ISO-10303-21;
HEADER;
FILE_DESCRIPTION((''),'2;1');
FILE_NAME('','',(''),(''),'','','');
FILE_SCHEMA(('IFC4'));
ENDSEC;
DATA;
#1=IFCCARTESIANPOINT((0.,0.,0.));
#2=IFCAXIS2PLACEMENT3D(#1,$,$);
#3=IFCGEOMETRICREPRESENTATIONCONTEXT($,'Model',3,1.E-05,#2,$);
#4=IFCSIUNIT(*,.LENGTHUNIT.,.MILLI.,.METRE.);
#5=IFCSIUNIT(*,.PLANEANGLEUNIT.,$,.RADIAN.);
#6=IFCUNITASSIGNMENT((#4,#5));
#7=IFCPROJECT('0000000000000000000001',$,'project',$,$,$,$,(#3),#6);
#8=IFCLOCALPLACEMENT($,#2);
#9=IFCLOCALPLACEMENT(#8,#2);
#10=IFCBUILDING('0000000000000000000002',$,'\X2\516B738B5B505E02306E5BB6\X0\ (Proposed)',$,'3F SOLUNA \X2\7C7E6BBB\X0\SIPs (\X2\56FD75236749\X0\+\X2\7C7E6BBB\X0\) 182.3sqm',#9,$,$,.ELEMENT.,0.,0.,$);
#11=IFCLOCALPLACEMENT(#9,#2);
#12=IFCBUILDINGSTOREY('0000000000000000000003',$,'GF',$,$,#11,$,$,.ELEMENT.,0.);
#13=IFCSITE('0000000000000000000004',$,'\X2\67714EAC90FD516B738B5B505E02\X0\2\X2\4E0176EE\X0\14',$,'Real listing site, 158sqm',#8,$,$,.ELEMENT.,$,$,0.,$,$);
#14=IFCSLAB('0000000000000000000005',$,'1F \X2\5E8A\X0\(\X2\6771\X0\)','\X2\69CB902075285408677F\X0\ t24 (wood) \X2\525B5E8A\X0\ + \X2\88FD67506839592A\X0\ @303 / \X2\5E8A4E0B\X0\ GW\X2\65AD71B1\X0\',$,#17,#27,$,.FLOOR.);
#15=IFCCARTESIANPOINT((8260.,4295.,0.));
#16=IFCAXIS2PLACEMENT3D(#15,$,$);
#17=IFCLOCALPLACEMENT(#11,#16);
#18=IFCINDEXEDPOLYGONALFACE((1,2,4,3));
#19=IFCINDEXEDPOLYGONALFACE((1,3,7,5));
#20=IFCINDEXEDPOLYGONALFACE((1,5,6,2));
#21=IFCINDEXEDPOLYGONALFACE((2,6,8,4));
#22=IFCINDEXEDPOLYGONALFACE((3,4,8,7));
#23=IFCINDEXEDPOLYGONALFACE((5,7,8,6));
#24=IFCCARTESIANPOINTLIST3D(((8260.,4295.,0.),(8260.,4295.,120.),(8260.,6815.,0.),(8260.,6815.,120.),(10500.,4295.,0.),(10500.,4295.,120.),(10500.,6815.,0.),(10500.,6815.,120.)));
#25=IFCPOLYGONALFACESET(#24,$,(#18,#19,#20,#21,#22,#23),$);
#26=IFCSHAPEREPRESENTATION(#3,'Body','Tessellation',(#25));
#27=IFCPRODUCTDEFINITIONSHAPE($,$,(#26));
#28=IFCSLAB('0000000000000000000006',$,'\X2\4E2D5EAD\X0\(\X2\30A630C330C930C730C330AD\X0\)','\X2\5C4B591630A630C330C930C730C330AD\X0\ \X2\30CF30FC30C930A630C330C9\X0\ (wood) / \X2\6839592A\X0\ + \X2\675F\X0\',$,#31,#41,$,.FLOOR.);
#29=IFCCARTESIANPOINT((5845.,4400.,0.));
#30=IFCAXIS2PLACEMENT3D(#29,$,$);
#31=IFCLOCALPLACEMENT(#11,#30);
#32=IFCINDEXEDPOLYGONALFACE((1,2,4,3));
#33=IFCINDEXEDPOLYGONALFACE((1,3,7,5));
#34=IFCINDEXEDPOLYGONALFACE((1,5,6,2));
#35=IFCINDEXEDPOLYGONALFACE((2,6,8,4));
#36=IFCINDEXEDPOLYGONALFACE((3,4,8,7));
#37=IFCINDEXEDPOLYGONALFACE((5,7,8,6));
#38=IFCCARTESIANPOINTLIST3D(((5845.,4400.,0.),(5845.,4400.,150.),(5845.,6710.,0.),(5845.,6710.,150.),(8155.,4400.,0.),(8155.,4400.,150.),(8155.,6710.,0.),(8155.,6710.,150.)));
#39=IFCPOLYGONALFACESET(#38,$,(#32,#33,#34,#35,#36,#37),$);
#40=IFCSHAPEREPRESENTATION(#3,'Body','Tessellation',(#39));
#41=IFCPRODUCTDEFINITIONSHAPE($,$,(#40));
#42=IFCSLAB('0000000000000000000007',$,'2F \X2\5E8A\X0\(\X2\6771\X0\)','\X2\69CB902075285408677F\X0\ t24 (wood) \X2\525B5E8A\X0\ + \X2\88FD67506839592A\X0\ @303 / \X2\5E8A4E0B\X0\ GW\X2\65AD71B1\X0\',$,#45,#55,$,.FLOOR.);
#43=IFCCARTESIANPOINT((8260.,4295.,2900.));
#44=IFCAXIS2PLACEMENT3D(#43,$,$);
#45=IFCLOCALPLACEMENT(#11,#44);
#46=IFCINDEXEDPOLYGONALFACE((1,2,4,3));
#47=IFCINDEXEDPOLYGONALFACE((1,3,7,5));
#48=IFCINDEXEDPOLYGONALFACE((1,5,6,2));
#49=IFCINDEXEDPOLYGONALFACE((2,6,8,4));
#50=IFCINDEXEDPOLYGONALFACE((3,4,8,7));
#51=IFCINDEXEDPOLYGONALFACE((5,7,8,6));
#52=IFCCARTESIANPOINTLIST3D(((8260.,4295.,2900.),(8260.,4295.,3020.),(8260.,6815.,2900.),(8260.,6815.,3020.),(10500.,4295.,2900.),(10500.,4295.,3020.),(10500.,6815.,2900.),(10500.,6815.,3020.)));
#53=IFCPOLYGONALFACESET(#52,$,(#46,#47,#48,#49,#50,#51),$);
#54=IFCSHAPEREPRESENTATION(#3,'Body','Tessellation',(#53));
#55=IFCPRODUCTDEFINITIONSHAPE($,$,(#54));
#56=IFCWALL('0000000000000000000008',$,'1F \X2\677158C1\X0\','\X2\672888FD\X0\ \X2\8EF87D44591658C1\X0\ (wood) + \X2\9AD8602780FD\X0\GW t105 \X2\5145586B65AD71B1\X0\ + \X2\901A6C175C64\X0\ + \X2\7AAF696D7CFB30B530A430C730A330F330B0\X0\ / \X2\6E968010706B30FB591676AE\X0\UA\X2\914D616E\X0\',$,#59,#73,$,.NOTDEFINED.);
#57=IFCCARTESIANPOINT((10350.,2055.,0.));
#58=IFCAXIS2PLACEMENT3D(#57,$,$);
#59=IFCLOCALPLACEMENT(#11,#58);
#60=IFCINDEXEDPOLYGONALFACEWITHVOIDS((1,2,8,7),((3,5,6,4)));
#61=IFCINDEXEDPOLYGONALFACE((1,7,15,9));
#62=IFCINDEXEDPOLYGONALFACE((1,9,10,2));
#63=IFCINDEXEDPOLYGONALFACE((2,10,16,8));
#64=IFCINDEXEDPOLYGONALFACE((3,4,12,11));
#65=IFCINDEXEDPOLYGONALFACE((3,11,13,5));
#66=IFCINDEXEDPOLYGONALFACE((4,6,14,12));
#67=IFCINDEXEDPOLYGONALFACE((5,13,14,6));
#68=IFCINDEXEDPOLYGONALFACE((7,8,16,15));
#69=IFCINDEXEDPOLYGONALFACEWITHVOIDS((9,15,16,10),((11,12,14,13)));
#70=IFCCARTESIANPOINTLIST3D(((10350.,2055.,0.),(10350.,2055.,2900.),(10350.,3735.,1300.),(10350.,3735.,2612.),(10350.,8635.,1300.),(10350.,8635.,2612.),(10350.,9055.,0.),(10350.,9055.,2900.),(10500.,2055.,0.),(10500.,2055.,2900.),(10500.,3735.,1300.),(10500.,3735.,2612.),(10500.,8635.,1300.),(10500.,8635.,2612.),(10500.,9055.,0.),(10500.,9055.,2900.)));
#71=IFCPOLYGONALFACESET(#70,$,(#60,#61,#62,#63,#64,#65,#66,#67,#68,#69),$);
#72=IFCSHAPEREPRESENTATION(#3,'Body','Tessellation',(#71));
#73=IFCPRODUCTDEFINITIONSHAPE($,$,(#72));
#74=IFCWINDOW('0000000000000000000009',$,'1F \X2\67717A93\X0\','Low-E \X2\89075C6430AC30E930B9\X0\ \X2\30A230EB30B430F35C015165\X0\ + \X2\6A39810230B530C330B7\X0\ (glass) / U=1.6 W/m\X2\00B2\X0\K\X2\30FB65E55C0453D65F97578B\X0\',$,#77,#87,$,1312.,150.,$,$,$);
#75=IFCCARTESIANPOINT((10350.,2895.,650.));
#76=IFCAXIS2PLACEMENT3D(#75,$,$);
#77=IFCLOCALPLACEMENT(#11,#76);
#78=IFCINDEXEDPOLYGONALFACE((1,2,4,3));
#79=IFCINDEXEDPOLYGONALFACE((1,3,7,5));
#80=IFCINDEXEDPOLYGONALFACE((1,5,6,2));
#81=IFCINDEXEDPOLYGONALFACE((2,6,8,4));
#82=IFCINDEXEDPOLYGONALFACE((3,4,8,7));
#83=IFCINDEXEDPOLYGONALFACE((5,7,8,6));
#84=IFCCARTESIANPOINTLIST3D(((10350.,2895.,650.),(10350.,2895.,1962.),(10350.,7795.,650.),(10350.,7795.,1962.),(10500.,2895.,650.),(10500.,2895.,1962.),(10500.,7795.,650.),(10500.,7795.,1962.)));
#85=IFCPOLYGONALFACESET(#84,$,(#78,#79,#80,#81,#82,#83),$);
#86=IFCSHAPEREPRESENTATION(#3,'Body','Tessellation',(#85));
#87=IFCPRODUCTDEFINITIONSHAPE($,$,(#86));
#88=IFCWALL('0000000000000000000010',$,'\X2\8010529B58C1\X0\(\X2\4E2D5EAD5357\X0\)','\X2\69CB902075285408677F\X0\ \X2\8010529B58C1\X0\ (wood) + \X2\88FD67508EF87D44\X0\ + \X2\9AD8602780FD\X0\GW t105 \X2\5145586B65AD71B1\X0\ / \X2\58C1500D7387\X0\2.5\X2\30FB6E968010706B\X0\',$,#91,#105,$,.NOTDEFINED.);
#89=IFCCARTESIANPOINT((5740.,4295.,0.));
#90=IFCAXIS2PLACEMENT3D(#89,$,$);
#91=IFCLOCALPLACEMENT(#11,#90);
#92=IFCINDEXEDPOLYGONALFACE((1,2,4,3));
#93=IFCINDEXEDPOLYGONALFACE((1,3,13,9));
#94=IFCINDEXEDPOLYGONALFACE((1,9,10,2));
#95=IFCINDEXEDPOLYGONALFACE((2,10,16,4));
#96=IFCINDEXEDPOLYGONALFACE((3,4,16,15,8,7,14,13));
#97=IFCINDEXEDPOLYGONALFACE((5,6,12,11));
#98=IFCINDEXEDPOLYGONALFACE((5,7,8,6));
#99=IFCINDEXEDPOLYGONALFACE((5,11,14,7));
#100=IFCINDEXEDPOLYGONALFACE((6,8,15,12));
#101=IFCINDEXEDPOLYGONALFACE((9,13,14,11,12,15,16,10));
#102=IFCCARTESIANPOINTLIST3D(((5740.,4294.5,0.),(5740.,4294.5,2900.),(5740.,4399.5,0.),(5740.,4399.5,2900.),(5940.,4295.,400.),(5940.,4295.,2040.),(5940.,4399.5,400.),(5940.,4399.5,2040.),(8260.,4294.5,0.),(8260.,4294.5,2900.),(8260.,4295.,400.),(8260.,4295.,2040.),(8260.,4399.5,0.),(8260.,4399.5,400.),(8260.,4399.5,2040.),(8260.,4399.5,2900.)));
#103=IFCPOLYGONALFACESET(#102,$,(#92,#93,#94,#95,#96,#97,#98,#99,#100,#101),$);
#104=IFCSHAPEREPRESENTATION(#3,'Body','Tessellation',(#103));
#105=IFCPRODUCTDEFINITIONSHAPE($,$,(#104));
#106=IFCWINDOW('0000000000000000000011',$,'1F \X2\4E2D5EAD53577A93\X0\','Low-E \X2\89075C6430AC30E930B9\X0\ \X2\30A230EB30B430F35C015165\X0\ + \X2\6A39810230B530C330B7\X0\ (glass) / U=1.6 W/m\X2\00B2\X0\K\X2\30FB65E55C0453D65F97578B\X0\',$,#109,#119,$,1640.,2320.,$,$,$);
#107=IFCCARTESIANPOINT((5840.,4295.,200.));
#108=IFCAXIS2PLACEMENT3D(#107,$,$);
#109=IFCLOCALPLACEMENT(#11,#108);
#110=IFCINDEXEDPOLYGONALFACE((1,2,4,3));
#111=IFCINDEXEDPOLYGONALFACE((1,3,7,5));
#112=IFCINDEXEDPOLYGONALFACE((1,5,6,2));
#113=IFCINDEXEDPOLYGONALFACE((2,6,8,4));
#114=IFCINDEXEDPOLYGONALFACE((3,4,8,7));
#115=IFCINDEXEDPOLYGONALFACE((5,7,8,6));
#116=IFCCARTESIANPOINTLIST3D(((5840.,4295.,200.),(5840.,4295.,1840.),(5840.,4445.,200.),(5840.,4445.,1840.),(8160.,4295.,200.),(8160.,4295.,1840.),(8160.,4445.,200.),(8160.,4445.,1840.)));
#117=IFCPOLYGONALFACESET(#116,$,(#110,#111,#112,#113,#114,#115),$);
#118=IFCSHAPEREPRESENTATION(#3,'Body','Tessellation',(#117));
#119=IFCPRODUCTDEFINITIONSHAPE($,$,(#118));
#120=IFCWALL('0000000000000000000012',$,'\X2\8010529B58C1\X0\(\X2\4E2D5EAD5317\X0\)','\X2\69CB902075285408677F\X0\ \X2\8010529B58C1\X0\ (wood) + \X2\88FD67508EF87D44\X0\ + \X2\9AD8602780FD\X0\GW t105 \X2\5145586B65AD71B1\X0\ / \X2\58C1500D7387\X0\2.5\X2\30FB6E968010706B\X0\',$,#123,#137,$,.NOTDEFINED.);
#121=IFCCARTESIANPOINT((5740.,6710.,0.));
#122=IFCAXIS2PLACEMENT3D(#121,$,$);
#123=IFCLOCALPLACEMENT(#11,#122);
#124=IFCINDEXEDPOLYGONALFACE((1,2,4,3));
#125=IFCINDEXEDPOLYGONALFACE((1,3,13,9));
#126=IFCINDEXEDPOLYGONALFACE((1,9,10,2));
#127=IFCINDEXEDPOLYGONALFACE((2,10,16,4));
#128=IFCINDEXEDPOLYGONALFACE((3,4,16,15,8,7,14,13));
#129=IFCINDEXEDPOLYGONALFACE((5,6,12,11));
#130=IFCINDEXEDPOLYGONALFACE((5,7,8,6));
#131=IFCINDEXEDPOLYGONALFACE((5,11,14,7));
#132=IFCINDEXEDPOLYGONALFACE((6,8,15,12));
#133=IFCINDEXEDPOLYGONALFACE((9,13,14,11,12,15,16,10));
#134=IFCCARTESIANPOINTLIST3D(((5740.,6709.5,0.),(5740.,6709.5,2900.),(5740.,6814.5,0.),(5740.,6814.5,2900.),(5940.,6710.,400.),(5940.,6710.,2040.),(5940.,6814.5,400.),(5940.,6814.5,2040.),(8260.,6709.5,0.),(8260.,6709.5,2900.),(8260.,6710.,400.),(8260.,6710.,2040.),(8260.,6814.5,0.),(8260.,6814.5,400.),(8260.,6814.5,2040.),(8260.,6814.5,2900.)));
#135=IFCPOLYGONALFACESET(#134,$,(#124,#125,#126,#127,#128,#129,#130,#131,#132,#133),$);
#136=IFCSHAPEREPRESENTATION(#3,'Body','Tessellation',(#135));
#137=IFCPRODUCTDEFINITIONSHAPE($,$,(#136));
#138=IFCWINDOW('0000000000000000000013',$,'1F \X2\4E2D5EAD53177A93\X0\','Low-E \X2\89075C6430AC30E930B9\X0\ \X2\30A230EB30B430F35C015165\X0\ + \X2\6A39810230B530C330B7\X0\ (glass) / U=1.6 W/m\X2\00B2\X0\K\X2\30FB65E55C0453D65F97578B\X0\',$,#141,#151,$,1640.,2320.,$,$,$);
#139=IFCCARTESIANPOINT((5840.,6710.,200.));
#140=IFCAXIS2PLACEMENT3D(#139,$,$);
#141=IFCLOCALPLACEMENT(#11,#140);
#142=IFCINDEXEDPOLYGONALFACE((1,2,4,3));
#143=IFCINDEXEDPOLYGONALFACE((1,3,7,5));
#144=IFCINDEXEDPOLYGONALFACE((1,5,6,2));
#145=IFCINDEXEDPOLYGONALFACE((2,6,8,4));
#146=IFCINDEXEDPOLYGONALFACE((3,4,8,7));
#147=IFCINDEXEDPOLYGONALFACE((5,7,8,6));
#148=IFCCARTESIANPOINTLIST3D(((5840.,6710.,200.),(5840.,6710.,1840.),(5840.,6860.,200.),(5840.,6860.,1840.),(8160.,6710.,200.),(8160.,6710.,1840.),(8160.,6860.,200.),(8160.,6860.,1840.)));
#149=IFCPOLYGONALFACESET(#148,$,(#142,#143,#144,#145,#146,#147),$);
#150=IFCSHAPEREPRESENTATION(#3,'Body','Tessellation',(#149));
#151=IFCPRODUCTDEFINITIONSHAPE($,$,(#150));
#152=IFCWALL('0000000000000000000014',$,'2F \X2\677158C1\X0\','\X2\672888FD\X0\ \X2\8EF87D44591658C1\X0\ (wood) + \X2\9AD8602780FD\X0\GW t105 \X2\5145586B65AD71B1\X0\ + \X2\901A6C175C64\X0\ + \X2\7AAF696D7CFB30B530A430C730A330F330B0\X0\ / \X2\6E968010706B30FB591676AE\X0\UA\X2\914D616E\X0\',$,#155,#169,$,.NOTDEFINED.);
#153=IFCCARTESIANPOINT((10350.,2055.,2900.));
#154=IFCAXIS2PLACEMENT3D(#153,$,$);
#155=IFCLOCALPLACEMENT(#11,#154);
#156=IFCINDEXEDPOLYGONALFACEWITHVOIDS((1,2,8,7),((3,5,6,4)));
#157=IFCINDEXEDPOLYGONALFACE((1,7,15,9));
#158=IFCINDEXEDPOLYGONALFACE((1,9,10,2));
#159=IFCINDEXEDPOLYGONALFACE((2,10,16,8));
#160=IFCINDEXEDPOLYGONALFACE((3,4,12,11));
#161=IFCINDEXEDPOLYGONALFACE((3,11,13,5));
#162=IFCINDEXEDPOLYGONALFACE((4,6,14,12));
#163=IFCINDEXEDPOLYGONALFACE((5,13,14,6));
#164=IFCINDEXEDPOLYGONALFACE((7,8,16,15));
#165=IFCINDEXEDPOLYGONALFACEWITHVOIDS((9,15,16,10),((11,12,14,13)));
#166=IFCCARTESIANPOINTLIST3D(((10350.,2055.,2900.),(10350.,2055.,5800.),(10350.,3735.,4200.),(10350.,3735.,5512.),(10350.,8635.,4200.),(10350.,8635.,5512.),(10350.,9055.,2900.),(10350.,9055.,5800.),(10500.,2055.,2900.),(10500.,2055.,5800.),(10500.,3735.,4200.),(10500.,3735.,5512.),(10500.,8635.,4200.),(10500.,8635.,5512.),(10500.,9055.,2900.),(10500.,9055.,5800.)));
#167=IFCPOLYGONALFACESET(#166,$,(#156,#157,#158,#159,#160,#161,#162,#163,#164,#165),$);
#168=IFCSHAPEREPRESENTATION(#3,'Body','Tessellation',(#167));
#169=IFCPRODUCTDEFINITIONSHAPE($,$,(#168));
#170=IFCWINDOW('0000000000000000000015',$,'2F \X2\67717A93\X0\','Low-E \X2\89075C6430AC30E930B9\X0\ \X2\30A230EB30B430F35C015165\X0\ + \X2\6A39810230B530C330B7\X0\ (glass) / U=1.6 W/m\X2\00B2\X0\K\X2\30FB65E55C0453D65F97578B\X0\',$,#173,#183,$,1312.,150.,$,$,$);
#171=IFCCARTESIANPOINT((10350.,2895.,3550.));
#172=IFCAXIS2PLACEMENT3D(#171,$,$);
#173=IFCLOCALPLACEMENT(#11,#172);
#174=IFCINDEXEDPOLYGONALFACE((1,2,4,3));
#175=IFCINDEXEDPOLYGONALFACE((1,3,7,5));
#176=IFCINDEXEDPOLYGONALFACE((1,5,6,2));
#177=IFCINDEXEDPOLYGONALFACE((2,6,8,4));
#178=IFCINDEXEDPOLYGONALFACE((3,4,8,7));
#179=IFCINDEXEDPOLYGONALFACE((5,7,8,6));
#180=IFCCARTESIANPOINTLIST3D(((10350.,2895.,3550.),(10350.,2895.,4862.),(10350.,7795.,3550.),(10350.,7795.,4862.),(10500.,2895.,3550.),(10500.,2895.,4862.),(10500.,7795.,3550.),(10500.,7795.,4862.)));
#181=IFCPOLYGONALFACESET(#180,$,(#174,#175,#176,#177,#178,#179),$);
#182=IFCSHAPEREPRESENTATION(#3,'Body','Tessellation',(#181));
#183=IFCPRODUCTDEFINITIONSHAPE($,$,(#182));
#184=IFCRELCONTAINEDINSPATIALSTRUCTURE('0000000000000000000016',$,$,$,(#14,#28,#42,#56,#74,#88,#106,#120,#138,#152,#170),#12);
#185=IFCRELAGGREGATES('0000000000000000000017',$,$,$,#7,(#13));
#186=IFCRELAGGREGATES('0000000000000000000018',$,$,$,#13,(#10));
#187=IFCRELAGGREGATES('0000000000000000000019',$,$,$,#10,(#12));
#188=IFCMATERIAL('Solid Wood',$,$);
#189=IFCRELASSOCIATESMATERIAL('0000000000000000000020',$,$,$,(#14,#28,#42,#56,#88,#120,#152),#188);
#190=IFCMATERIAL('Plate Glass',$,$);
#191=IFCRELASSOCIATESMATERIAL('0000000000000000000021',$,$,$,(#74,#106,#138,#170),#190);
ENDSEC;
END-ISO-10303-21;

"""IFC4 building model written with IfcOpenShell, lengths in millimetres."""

from ifc_helpers import new_model, si_unit, frame, frame_2d, origin, place, context, project, spatial, rectangle, extrude, material, element, fill, save


model = new_model("IFC4")

# Units and contexts
model_context = context("Model", 3, precision=1e-05, world=origin())
ifc_project = project(units=[si_unit("LENGTHUNIT", "METRE", prefix="MILLI"), si_unit("PLANEANGLEUNIT", "RADIAN")], contexts=[model_context])

# Site, building, storey
site_placement = place(None, origin())
site = spatial("IfcSite", under=ifc_project, at=site_placement, Name="東京都八王子市2丁目14", ObjectType="Real listing site, 158sqm", CompositionType="ELEMENT", RefElevation=0.0)
building_placement = place(site_placement, origin())
building = spatial("IfcBuilding", under=site, at=building_placement, Name="八王子市の家 (Proposed)", ObjectType="3F SOLUNA 籾殻SIPs (国産杉+籾殻) 182.3sqm", CompositionType="ELEMENT", ElevationOfRefHeight=0.0, ElevationOfTerrain=0.0)
storey_placement = place(building_placement, origin())
storey = spatial("IfcBuildingStorey", under=building, at=storey_placement, Name="GF", CompositionType="ELEMENT", Elevation=0.0)

# Slabs
ifc_material_1 = material(Name="Solid Wood")
slab_1_placement = place(storey_placement, frame((8260.0, 4295.0, 0.0)))
element("IfcSlab", 1, at=slab_1_placement, inside=storey, material=ifc_material_1, Name="1F 床(東)", Description="構造用合板 t24 (wood) 剛床 + 製材根太 @303 / 床下 GW断熱", PredefinedType="FLOOR", context=model_context, shape_type="SweptSolid", body=[
    extrude(rectangle(XDim=2240.0, YDim=2520.0, at=frame_2d((1120.0, 1260.0))), frame((8260.0, 4295.0, 0.0)), (0.0, 0.0, 1.0), 120.0),
])
slab_2_placement = place(storey_placement, frame((5845.0, 4400.0, 0.0)))
element("IfcSlab", 2, at=slab_2_placement, inside=storey, material=ifc_material_1, Name="中庭(ウッドデッキ)", Description="屋外ウッドデッキ ハードウッド (wood) / 根太 + 束", PredefinedType="FLOOR", context=model_context, shape_type="SweptSolid", body=[
    extrude(rectangle(XDim=2310.0, YDim=2310.0, at=frame_2d((1155.0, 1155.0))), frame((5845.0, 4400.0, 0.0)), (0.0, 0.0, 1.0), 150.0),
])
slab_3_placement = place(storey_placement, frame((8260.0, 4295.0, 2900.0)))
element("IfcSlab", 3, at=slab_3_placement, inside=storey, material=ifc_material_1, Name="2F 床(東)", Description="構造用合板 t24 (wood) 剛床 + 製材根太 @303 / 床下 GW断熱", PredefinedType="FLOOR", context=model_context, shape_type="SweptSolid", body=[
    extrude(rectangle(XDim=2240.0, YDim=2520.0, at=frame_2d((1120.0, 1260.0))), frame((8260.0, 4295.0, 2900.0)), (0.0, 0.0, 1.0), 120.0),
])

# Walls, openings, windows
wall_1_placement = place(storey_placement, frame((10350.0, 2055.0, 0.0)))
wall_1 = element("IfcWall", 4, at=wall_1_placement, inside=storey, material=ifc_material_1, Name="1F 東壁", Description="木製 軸組外壁 (wood) + 高性能GW t105 充填断熱 + 通気層 + 窯業系サイディング / 準耐火・外皮UA配慮", PredefinedType="NOTDEFINED", context=model_context, shape_type="SweptSolid", body=[
    extrude(rectangle(XDim=150.0, YDim=7000.0, at=frame_2d((75.0, 3500.0))), frame((10350.0, 2055.0, 0.0)), (0.0, 0.0, 1.0), 2900.0),
])
opening_1_placement = place(storey_placement, frame((10350.0, 2895.0, 650.0)))
opening_1 = element("IfcOpeningElement", 5, at=opening_1_placement, cuts=wall_1, PredefinedType="NOTDEFINED", context=model_context, shape_type="SweptSolid", body=[
    extrude(rectangle(XDim=150.0, YDim=4900.0, at=frame_2d((75.0, 2450.0))), frame((10350.0, 2895.0, 650.0)), (0.0, 0.0, 1.0), 1312.0),
])
ifc_material_2 = material(Name="Plate Glass")
window_1_placement = place(storey_placement, frame((10350.0, 2895.0, 650.0)))
window_1 = element("IfcWindow", 6, at=window_1_placement, inside=storey, material=ifc_material_2, Name="1F 東窓", Description="Low-E 複層ガラス アルゴン封入 + 樹脂サッシ (glass) / U=1.6 W/m²K・日射取得型", OverallHeight=1312.0, OverallWidth=150.0, context=model_context, shape_type="SweptSolid", body=[
    extrude(rectangle(XDim=150.0, YDim=4900.0, at=frame_2d((75.0, 2450.0))), frame((10350.0, 2895.0, 650.0)), (0.0, 0.0, 1.0), 1312.0),
])
fill(opening_1, window_1)
wall_2_placement = place(storey_placement, frame((5740.0, 4295.0, 0.0)))
wall_2 = element("IfcWall", 7, at=wall_2_placement, inside=storey, material=ifc_material_1, Name="耐力壁(中庭南)", Description="構造用合板 耐力壁 (wood) + 製材軸組 + 高性能GW t105 充填断熱 / 壁倍率2.5・準耐火", PredefinedType="NOTDEFINED", context=model_context, shape_type="SweptSolid", body=[
    extrude(rectangle(XDim=2520.0, YDim=105.0, at=frame_2d((1260.0, 52.0))), frame((5740.0, 4295.0, 0.0)), (0.0, 0.0, 1.0), 2900.0),
])
opening_2_placement = place(storey_placement, frame((5840.0, 4295.0, 200.0)))
opening_2 = element("IfcOpeningElement", 8, at=opening_2_placement, cuts=wall_2, PredefinedType="NOTDEFINED", context=model_context, shape_type="SweptSolid", body=[
    extrude(rectangle(XDim=2320.0, YDim=150.0, at=frame_2d((1160.0, 75.0))), frame((5840.0, 4295.0, 200.0)), (0.0, 0.0, 1.0), 1640.0),
])
window_2_placement = place(storey_placement, frame((5840.0, 4295.0, 200.0)))
window_2 = element("IfcWindow", 9, at=window_2_placement, inside=storey, material=ifc_material_2, Name="1F 中庭南窓", Description="Low-E 複層ガラス アルゴン封入 + 樹脂サッシ (glass) / U=1.6 W/m²K・日射取得型", OverallHeight=1640.0, OverallWidth=2320.0, context=model_context, shape_type="SweptSolid", body=[
    extrude(rectangle(XDim=2320.0, YDim=150.0, at=frame_2d((1160.0, 75.0))), frame((5840.0, 4295.0, 200.0)), (0.0, 0.0, 1.0), 1640.0),
])
fill(opening_2, window_2)
wall_3_placement = place(storey_placement, frame((5740.0, 6710.0, 0.0)))
wall_3 = element("IfcWall", 10, at=wall_3_placement, inside=storey, material=ifc_material_1, Name="耐力壁(中庭北)", Description="構造用合板 耐力壁 (wood) + 製材軸組 + 高性能GW t105 充填断熱 / 壁倍率2.5・準耐火", PredefinedType="NOTDEFINED", context=model_context, shape_type="SweptSolid", body=[
    extrude(rectangle(XDim=2520.0, YDim=105.0, at=frame_2d((1260.0, 52.0))), frame((5740.0, 6710.0, 0.0)), (0.0, 0.0, 1.0), 2900.0),
])
opening_3_placement = place(storey_placement, frame((5840.0, 6710.0, 200.0)))
opening_3 = element("IfcOpeningElement", 11, at=opening_3_placement, cuts=wall_3, PredefinedType="NOTDEFINED", context=model_context, shape_type="SweptSolid", body=[
    extrude(rectangle(XDim=2320.0, YDim=150.0, at=frame_2d((1160.0, 75.0))), frame((5840.0, 6710.0, 200.0)), (0.0, 0.0, 1.0), 1640.0),
])
window_3_placement = place(storey_placement, frame((5840.0, 6710.0, 200.0)))
window_3 = element("IfcWindow", 12, at=window_3_placement, inside=storey, material=ifc_material_2, Name="1F 中庭北窓", Description="Low-E 複層ガラス アルゴン封入 + 樹脂サッシ (glass) / U=1.6 W/m²K・日射取得型", OverallHeight=1640.0, OverallWidth=2320.0, context=model_context, shape_type="SweptSolid", body=[
    extrude(rectangle(XDim=2320.0, YDim=150.0, at=frame_2d((1160.0, 75.0))), frame((5840.0, 6710.0, 200.0)), (0.0, 0.0, 1.0), 1640.0),
])
fill(opening_3, window_3)

# Wall, opening, window
wall_4_placement = place(storey_placement, frame((10350.0, 2055.0, 2900.0)))
wall_4 = element("IfcWall", 13, at=wall_4_placement, inside=storey, material=ifc_material_1, Name="2F 東壁", Description="木製 軸組外壁 (wood) + 高性能GW t105 充填断熱 + 通気層 + 窯業系サイディング / 準耐火・外皮UA配慮", PredefinedType="NOTDEFINED", context=model_context, shape_type="SweptSolid", body=[
    extrude(rectangle(XDim=150.0, YDim=7000.0, at=frame_2d((75.0, 3500.0))), frame((10350.0, 2055.0, 2900.0)), (0.0, 0.0, 1.0), 2900.0),
])
opening_4_placement = place(storey_placement, frame((10350.0, 2895.0, 3550.0)))
opening_4 = element("IfcOpeningElement", 14, at=opening_4_placement, cuts=wall_4, PredefinedType="NOTDEFINED", context=model_context, shape_type="SweptSolid", body=[
    extrude(rectangle(XDim=150.0, YDim=4900.0, at=frame_2d((75.0, 2450.0))), frame((10350.0, 2895.0, 3550.0)), (0.0, 0.0, 1.0), 1312.0),
])
window_4_placement = place(storey_placement, frame((10350.0, 2895.0, 3550.0)))
window_4 = element("IfcWindow", 15, at=window_4_placement, inside=storey, material=ifc_material_2, Name="2F 東窓", Description="Low-E 複層ガラス アルゴン封入 + 樹脂サッシ (glass) / U=1.6 W/m²K・日射取得型", OverallHeight=1312.0, OverallWidth=150.0, context=model_context, shape_type="SweptSolid", body=[
    extrude(rectangle(XDim=150.0, YDim=4900.0, at=frame_2d((75.0, 2450.0))), frame((10350.0, 2895.0, 3550.0)), (0.0, 0.0, 1.0), 1312.0),
])
fill(opening_4, window_4)

save(model, "model.ifc")
